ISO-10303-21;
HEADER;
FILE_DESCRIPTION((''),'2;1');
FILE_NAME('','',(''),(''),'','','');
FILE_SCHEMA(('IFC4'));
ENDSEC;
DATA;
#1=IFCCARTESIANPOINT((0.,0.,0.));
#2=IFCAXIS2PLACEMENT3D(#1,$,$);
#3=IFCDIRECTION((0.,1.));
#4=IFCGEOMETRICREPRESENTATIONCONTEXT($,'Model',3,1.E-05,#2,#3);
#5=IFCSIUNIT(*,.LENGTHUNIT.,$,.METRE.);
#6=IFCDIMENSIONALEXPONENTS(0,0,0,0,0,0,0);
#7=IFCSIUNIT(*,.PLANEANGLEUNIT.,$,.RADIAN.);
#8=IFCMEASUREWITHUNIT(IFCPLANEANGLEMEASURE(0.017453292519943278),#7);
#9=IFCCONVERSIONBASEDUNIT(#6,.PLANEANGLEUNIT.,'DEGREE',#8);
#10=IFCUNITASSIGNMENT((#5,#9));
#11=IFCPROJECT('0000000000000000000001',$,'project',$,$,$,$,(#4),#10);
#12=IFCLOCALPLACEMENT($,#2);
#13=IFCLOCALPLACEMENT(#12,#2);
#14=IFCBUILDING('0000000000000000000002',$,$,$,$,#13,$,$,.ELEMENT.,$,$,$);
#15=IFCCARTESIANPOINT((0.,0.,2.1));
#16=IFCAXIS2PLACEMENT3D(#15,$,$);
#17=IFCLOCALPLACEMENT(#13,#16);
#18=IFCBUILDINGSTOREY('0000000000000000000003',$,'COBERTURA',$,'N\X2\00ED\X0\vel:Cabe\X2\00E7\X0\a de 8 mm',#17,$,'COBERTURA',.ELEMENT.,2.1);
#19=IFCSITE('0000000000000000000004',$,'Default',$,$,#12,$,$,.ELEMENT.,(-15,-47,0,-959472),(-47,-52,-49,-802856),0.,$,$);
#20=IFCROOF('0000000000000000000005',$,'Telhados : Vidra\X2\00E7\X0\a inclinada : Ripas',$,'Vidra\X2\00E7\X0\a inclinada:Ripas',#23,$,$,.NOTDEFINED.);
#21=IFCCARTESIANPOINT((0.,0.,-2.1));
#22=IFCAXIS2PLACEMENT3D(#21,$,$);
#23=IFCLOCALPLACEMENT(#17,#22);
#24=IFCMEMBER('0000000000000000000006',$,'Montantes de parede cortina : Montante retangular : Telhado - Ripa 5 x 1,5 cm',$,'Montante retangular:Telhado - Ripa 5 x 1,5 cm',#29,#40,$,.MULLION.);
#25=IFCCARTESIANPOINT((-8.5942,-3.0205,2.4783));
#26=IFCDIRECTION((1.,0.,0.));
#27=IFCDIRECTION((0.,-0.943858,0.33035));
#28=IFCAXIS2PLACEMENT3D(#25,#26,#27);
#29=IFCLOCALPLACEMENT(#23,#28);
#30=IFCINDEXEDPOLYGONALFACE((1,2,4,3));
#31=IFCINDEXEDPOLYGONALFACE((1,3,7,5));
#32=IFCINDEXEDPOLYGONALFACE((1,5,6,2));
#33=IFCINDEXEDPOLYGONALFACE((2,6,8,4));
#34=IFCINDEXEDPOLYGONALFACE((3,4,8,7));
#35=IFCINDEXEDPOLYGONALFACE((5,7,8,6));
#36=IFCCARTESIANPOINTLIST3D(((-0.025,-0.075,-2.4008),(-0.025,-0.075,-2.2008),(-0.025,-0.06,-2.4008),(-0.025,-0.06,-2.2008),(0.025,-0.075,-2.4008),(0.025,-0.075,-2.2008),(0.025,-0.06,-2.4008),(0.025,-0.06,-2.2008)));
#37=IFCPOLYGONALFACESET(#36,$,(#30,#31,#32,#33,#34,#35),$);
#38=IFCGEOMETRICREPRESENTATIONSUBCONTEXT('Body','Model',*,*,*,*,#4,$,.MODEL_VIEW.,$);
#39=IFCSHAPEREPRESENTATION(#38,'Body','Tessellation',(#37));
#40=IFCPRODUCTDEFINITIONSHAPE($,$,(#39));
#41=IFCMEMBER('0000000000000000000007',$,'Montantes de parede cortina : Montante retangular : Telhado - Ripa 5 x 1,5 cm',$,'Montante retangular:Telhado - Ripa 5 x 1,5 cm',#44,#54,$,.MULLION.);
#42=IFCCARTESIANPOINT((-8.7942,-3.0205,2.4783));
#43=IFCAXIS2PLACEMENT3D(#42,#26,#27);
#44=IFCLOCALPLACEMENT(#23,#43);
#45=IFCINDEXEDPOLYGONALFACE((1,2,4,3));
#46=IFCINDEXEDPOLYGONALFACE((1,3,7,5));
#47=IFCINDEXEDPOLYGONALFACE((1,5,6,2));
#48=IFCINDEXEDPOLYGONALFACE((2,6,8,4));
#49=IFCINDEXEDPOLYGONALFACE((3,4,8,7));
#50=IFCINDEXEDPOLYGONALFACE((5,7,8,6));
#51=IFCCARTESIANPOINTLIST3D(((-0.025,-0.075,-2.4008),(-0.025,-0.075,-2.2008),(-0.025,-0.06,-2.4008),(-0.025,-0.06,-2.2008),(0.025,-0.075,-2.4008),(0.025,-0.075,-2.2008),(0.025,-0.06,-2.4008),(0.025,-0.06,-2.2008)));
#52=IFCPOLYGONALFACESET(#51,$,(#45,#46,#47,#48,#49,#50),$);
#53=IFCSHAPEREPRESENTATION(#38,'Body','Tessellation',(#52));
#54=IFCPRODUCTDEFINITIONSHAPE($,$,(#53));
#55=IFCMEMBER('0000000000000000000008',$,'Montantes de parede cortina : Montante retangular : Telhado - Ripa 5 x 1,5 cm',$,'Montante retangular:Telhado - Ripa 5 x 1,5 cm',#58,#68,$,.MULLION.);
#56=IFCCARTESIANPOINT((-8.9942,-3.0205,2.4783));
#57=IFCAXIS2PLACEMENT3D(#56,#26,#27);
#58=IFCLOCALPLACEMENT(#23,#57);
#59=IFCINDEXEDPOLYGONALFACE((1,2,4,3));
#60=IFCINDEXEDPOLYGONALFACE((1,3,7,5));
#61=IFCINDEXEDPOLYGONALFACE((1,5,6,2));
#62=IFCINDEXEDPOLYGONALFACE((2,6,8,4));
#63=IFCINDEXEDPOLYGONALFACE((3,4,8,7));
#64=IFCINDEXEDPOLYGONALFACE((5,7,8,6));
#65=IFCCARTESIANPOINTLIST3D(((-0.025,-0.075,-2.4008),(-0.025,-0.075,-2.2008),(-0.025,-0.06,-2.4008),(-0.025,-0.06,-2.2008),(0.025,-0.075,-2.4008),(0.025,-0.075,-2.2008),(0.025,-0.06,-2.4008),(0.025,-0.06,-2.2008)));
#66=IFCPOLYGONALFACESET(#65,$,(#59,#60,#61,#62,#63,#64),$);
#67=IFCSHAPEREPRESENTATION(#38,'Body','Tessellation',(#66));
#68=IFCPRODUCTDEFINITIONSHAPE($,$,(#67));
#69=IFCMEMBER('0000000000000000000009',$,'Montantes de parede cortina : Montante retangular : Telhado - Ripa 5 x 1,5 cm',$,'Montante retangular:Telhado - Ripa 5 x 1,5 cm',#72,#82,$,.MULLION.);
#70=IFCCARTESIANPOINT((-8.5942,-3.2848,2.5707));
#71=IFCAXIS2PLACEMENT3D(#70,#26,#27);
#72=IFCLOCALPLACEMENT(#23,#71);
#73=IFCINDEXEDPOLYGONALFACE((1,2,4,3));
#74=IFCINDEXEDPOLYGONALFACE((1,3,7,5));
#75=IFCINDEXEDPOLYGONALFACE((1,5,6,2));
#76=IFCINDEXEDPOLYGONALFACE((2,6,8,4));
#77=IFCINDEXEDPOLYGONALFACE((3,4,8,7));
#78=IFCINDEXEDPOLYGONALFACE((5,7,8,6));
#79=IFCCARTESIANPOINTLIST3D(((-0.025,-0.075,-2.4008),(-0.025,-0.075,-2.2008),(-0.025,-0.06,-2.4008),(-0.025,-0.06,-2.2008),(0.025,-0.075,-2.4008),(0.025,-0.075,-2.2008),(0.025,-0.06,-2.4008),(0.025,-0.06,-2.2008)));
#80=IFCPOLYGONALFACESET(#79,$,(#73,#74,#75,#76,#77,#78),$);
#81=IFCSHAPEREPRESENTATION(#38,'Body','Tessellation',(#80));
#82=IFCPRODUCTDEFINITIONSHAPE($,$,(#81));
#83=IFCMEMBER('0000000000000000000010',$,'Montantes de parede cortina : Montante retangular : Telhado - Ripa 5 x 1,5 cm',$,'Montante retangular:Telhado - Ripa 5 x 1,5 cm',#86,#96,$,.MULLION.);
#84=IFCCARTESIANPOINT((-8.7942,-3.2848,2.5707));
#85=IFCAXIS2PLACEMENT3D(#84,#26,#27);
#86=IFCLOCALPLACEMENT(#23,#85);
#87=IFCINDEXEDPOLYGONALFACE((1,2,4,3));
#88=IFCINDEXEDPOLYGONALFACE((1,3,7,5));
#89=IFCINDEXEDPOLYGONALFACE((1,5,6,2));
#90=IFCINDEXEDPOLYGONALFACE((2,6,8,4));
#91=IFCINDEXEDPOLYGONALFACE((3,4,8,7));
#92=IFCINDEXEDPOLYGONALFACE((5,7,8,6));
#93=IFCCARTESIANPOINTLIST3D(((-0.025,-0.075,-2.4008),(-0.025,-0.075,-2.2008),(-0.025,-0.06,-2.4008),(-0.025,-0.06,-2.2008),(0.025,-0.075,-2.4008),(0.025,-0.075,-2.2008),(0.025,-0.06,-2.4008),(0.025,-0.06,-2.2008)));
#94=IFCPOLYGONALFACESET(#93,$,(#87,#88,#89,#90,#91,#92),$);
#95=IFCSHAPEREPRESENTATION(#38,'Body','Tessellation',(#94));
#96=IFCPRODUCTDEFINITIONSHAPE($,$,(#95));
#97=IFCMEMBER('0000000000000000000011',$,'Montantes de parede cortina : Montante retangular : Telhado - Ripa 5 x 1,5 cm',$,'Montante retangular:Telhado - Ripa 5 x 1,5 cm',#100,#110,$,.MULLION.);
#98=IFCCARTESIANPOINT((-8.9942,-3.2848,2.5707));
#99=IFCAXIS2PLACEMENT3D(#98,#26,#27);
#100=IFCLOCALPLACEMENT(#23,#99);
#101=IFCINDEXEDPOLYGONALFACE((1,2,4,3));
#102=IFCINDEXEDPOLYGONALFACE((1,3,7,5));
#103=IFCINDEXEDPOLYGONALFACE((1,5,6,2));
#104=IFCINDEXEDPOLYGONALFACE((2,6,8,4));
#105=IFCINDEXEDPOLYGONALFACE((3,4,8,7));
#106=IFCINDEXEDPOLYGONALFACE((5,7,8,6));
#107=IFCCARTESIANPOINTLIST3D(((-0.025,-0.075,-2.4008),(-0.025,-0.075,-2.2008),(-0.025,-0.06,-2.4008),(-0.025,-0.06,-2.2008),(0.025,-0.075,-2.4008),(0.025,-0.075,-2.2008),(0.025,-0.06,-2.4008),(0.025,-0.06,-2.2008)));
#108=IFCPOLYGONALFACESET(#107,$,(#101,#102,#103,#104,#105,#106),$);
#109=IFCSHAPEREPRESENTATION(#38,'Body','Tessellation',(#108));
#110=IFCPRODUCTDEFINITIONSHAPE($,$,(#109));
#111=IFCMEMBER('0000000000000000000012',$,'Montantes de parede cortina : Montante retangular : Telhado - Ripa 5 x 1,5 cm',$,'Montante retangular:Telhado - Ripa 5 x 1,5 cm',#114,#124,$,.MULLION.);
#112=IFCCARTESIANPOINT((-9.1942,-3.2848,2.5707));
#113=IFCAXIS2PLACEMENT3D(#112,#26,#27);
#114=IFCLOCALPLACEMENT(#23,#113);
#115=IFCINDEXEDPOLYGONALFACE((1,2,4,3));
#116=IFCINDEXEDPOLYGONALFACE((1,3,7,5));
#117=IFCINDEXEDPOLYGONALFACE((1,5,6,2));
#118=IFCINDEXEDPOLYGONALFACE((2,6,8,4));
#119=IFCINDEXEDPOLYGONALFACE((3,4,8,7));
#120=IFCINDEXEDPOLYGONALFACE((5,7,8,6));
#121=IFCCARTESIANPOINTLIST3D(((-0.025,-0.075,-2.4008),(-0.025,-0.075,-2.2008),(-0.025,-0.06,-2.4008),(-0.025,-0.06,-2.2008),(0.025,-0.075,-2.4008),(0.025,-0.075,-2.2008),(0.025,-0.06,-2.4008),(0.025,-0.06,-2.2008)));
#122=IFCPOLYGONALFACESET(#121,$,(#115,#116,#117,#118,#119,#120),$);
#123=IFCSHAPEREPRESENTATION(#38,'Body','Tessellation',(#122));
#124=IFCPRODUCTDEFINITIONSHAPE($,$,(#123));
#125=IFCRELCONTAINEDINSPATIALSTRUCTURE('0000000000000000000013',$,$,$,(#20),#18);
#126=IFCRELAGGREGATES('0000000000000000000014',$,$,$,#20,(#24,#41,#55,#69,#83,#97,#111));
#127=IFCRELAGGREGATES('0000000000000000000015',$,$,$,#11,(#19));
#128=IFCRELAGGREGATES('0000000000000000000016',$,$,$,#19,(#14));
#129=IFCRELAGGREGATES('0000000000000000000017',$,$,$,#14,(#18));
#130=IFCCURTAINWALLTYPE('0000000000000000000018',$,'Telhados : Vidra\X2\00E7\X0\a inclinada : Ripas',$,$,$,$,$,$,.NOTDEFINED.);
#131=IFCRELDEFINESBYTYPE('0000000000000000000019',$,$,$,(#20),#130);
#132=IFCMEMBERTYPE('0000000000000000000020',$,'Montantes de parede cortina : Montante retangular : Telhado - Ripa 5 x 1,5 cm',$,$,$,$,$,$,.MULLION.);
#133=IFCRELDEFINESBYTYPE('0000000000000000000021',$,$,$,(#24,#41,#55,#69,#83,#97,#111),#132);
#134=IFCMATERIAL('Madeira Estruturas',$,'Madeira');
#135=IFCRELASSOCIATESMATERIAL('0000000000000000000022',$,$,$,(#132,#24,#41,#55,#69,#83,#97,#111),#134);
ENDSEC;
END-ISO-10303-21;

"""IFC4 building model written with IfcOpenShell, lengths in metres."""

from ifc_helpers import new_model, entity, si_unit, converted_unit, direction, frame, origin, place, context, subcontext, project, spatial, indexed_curve, outline, extrude, source, transform, mapped, material, type_object, type_shapes, element, aggregate, save


model = new_model("IFC4")

# Units and contexts
model_context = context("Model", 3, precision=1e-05, world=origin(), true_north=direction((0.0, 1.0)))
body_context = subcontext(model_context, "Body", "Model", "MODEL_VIEW")
ifc_project = project(units=[si_unit("LENGTHUNIT", "METRE"), converted_unit("PLANEANGLEUNIT", "DEGREE", entity("IfcPlaneAngleMeasure", 0.017453292519943278), si_unit("PLANEANGLEUNIT", "RADIAN"), dimensions=[0, 0, 0, 0, 0, 0, 0])], contexts=[model_context])

# Site, building, storey
site_placement = place(None, origin())
site = spatial("IfcSite", under=ifc_project, at=site_placement, Name="Default", CompositionType="ELEMENT", RefLatitude=(-15, -47, 0, -959472), RefLongitude=(-47, -52, -49, -802856), RefElevation=0.0)
building_placement = place(site_placement, origin())
building = spatial("IfcBuilding", under=site, at=building_placement, CompositionType="ELEMENT")
storey_placement = place(building_placement, frame((0.0, 0.0, 2.1)))
storey = spatial("IfcBuildingStorey", under=building, at=storey_placement, Name="COBERTURA", ObjectType="Nível:Cabeça de 8 mm", LongName="COBERTURA", CompositionType="ELEMENT", Elevation=2.1)

# Roof, members
curtain_wall_type = type_object("IfcCurtainWallType", Name="Telhados : Vidraça inclinada : Ripas", PredefinedType="NOTDEFINED")
roof_placement = place(storey_placement, frame((0.0, 0.0, -2.1)))
roof = element("IfcRoof", 1, at=roof_placement, inside=storey, type_object=curtain_wall_type, Name="Telhados : Vidraça inclinada : Ripas", ObjectType="Vidraça inclinada:Ripas", PredefinedType="NOTDEFINED")
ifc_material = material(Name="Madeira Estruturas", Category="Madeira")
member_type_1 = type_object("IfcMemberType", Name="Montantes de parede cortina : Montante retangular : Telhado - Ripa 5 x 1,5 cm", PredefinedType="MULLION", material=ifc_material)
shared_shape_1 = source(origin(), body_context, "Body", "SweptSolid", [
    extrude(outline(indexed_curve([(-0.025, -0.0075), (0.025, -0.0075), (0.025, 0.0075), (-0.025, 0.0075), (-0.025, -0.0075)], self_intersect=False)), frame((0.0, -0.0675, -2.4008), z_axis=(0.0, 0.0, 1.0), x_axis=(-1.0, 0.0, 0.0)), (0.0, 0.0, 1.0), 0.2),
])
type_shapes(member_type_1, [shared_shape_1])
member_1_placement = place(roof_placement, frame((-8.5942, -3.0205, 2.4783), z_axis=(1.0, 0.0, 0.0), x_axis=(0.0, -0.943858, 0.33035)))
member_1 = element("IfcMember", 2, at=member_1_placement, type_object=member_type_1, material=ifc_material, Name="Montantes de parede cortina : Montante retangular : Telhado - Ripa 5 x 1,5 cm", ObjectType="Montante retangular:Telhado - Ripa 5 x 1,5 cm", PredefinedType="MULLION", context=body_context, shape_type="MappedRepresentation", body=[
    mapped(shared_shape_1, transform((0.0, 0.0, 0.0), scale=1.0)),
])
member_2_placement = place(roof_placement, frame((-8.7942, -3.0205, 2.4783), z_axis=(1.0, 0.0, 0.0), x_axis=(0.0, -0.943858, 0.33035)))
member_2 = element("IfcMember", 3, at=member_2_placement, type_object=member_type_1, material=ifc_material, Name="Montantes de parede cortina : Montante retangular : Telhado - Ripa 5 x 1,5 cm", ObjectType="Montante retangular:Telhado - Ripa 5 x 1,5 cm", PredefinedType="MULLION", context=body_context, shape_type="MappedRepresentation", body=[
    mapped(shared_shape_1, transform((0.0, 0.0, 0.0), scale=1.0)),
])
member_3_placement = place(roof_placement, frame((-8.9942, -3.0205, 2.4783), z_axis=(1.0, 0.0, 0.0), x_axis=(0.0, -0.943858, 0.33035)))
member_3 = element("IfcMember", 4, at=member_3_placement, type_object=member_type_1, material=ifc_material, Name="Montantes de parede cortina : Montante retangular : Telhado - Ripa 5 x 1,5 cm", ObjectType="Montante retangular:Telhado - Ripa 5 x 1,5 cm", PredefinedType="MULLION", context=body_context, shape_type="MappedRepresentation", body=[
    mapped(shared_shape_1, transform((0.0, 0.0, 0.0), scale=1.0)),
])
member_4_placement = place(roof_placement, frame((-8.5942, -3.2848, 2.5707), z_axis=(1.0, 0.0, 0.0), x_axis=(0.0, -0.943858, 0.33035)))
member_4 = element("IfcMember", 5, at=member_4_placement, type_object=member_type_1, material=ifc_material, Name="Montantes de parede cortina : Montante retangular : Telhado - Ripa 5 x 1,5 cm", ObjectType="Montante retangular:Telhado - Ripa 5 x 1,5 cm", PredefinedType="MULLION", context=body_context, shape_type="MappedRepresentation", body=[
    mapped(shared_shape_1, transform((0.0, 0.0, 0.0), scale=1.0)),
])
member_5_placement = place(roof_placement, frame((-8.7942, -3.2848, 2.5707), z_axis=(1.0, 0.0, 0.0), x_axis=(0.0, -0.943858, 0.33035)))
member_5 = element("IfcMember", 6, at=member_5_placement, type_object=member_type_1, material=ifc_material, Name="Montantes de parede cortina : Montante retangular : Telhado - Ripa 5 x 1,5 cm", ObjectType="Montante retangular:Telhado - Ripa 5 x 1,5 cm", PredefinedType="MULLION", context=body_context, shape_type="MappedRepresentation", body=[
    mapped(shared_shape_1, transform((0.0, 0.0, 0.0), scale=1.0)),
])
member_6_placement = place(roof_placement, frame((-8.9942, -3.2848, 2.5707), z_axis=(1.0, 0.0, 0.0), x_axis=(0.0, -0.943858, 0.33035)))
member_6 = element("IfcMember", 7, at=member_6_placement, type_object=member_type_1, material=ifc_material, Name="Montantes de parede cortina : Montante retangular : Telhado - Ripa 5 x 1,5 cm", ObjectType="Montante retangular:Telhado - Ripa 5 x 1,5 cm", PredefinedType="MULLION", context=body_context, shape_type="MappedRepresentation", body=[
    mapped(shared_shape_1, transform((0.0, 0.0, 0.0), scale=1.0)),
])
member_7_placement = place(roof_placement, frame((-9.1942, -3.2848, 2.5707), z_axis=(1.0, 0.0, 0.0), x_axis=(0.0, -0.943858, 0.33035)))
member_7 = element("IfcMember", 8, at=member_7_placement, type_object=member_type_1, material=ifc_material, Name="Montantes de parede cortina : Montante retangular : Telhado - Ripa 5 x 1,5 cm", ObjectType="Montante retangular:Telhado - Ripa 5 x 1,5 cm", PredefinedType="MULLION", context=body_context, shape_type="MappedRepresentation", body=[
    mapped(shared_shape_1, transform((0.0, 0.0, 0.0), scale=1.0)),
])
aggregate(roof, [member_1, member_2, member_3, member_4, member_5, member_6, member_7])

save(model, "model.ifc")
